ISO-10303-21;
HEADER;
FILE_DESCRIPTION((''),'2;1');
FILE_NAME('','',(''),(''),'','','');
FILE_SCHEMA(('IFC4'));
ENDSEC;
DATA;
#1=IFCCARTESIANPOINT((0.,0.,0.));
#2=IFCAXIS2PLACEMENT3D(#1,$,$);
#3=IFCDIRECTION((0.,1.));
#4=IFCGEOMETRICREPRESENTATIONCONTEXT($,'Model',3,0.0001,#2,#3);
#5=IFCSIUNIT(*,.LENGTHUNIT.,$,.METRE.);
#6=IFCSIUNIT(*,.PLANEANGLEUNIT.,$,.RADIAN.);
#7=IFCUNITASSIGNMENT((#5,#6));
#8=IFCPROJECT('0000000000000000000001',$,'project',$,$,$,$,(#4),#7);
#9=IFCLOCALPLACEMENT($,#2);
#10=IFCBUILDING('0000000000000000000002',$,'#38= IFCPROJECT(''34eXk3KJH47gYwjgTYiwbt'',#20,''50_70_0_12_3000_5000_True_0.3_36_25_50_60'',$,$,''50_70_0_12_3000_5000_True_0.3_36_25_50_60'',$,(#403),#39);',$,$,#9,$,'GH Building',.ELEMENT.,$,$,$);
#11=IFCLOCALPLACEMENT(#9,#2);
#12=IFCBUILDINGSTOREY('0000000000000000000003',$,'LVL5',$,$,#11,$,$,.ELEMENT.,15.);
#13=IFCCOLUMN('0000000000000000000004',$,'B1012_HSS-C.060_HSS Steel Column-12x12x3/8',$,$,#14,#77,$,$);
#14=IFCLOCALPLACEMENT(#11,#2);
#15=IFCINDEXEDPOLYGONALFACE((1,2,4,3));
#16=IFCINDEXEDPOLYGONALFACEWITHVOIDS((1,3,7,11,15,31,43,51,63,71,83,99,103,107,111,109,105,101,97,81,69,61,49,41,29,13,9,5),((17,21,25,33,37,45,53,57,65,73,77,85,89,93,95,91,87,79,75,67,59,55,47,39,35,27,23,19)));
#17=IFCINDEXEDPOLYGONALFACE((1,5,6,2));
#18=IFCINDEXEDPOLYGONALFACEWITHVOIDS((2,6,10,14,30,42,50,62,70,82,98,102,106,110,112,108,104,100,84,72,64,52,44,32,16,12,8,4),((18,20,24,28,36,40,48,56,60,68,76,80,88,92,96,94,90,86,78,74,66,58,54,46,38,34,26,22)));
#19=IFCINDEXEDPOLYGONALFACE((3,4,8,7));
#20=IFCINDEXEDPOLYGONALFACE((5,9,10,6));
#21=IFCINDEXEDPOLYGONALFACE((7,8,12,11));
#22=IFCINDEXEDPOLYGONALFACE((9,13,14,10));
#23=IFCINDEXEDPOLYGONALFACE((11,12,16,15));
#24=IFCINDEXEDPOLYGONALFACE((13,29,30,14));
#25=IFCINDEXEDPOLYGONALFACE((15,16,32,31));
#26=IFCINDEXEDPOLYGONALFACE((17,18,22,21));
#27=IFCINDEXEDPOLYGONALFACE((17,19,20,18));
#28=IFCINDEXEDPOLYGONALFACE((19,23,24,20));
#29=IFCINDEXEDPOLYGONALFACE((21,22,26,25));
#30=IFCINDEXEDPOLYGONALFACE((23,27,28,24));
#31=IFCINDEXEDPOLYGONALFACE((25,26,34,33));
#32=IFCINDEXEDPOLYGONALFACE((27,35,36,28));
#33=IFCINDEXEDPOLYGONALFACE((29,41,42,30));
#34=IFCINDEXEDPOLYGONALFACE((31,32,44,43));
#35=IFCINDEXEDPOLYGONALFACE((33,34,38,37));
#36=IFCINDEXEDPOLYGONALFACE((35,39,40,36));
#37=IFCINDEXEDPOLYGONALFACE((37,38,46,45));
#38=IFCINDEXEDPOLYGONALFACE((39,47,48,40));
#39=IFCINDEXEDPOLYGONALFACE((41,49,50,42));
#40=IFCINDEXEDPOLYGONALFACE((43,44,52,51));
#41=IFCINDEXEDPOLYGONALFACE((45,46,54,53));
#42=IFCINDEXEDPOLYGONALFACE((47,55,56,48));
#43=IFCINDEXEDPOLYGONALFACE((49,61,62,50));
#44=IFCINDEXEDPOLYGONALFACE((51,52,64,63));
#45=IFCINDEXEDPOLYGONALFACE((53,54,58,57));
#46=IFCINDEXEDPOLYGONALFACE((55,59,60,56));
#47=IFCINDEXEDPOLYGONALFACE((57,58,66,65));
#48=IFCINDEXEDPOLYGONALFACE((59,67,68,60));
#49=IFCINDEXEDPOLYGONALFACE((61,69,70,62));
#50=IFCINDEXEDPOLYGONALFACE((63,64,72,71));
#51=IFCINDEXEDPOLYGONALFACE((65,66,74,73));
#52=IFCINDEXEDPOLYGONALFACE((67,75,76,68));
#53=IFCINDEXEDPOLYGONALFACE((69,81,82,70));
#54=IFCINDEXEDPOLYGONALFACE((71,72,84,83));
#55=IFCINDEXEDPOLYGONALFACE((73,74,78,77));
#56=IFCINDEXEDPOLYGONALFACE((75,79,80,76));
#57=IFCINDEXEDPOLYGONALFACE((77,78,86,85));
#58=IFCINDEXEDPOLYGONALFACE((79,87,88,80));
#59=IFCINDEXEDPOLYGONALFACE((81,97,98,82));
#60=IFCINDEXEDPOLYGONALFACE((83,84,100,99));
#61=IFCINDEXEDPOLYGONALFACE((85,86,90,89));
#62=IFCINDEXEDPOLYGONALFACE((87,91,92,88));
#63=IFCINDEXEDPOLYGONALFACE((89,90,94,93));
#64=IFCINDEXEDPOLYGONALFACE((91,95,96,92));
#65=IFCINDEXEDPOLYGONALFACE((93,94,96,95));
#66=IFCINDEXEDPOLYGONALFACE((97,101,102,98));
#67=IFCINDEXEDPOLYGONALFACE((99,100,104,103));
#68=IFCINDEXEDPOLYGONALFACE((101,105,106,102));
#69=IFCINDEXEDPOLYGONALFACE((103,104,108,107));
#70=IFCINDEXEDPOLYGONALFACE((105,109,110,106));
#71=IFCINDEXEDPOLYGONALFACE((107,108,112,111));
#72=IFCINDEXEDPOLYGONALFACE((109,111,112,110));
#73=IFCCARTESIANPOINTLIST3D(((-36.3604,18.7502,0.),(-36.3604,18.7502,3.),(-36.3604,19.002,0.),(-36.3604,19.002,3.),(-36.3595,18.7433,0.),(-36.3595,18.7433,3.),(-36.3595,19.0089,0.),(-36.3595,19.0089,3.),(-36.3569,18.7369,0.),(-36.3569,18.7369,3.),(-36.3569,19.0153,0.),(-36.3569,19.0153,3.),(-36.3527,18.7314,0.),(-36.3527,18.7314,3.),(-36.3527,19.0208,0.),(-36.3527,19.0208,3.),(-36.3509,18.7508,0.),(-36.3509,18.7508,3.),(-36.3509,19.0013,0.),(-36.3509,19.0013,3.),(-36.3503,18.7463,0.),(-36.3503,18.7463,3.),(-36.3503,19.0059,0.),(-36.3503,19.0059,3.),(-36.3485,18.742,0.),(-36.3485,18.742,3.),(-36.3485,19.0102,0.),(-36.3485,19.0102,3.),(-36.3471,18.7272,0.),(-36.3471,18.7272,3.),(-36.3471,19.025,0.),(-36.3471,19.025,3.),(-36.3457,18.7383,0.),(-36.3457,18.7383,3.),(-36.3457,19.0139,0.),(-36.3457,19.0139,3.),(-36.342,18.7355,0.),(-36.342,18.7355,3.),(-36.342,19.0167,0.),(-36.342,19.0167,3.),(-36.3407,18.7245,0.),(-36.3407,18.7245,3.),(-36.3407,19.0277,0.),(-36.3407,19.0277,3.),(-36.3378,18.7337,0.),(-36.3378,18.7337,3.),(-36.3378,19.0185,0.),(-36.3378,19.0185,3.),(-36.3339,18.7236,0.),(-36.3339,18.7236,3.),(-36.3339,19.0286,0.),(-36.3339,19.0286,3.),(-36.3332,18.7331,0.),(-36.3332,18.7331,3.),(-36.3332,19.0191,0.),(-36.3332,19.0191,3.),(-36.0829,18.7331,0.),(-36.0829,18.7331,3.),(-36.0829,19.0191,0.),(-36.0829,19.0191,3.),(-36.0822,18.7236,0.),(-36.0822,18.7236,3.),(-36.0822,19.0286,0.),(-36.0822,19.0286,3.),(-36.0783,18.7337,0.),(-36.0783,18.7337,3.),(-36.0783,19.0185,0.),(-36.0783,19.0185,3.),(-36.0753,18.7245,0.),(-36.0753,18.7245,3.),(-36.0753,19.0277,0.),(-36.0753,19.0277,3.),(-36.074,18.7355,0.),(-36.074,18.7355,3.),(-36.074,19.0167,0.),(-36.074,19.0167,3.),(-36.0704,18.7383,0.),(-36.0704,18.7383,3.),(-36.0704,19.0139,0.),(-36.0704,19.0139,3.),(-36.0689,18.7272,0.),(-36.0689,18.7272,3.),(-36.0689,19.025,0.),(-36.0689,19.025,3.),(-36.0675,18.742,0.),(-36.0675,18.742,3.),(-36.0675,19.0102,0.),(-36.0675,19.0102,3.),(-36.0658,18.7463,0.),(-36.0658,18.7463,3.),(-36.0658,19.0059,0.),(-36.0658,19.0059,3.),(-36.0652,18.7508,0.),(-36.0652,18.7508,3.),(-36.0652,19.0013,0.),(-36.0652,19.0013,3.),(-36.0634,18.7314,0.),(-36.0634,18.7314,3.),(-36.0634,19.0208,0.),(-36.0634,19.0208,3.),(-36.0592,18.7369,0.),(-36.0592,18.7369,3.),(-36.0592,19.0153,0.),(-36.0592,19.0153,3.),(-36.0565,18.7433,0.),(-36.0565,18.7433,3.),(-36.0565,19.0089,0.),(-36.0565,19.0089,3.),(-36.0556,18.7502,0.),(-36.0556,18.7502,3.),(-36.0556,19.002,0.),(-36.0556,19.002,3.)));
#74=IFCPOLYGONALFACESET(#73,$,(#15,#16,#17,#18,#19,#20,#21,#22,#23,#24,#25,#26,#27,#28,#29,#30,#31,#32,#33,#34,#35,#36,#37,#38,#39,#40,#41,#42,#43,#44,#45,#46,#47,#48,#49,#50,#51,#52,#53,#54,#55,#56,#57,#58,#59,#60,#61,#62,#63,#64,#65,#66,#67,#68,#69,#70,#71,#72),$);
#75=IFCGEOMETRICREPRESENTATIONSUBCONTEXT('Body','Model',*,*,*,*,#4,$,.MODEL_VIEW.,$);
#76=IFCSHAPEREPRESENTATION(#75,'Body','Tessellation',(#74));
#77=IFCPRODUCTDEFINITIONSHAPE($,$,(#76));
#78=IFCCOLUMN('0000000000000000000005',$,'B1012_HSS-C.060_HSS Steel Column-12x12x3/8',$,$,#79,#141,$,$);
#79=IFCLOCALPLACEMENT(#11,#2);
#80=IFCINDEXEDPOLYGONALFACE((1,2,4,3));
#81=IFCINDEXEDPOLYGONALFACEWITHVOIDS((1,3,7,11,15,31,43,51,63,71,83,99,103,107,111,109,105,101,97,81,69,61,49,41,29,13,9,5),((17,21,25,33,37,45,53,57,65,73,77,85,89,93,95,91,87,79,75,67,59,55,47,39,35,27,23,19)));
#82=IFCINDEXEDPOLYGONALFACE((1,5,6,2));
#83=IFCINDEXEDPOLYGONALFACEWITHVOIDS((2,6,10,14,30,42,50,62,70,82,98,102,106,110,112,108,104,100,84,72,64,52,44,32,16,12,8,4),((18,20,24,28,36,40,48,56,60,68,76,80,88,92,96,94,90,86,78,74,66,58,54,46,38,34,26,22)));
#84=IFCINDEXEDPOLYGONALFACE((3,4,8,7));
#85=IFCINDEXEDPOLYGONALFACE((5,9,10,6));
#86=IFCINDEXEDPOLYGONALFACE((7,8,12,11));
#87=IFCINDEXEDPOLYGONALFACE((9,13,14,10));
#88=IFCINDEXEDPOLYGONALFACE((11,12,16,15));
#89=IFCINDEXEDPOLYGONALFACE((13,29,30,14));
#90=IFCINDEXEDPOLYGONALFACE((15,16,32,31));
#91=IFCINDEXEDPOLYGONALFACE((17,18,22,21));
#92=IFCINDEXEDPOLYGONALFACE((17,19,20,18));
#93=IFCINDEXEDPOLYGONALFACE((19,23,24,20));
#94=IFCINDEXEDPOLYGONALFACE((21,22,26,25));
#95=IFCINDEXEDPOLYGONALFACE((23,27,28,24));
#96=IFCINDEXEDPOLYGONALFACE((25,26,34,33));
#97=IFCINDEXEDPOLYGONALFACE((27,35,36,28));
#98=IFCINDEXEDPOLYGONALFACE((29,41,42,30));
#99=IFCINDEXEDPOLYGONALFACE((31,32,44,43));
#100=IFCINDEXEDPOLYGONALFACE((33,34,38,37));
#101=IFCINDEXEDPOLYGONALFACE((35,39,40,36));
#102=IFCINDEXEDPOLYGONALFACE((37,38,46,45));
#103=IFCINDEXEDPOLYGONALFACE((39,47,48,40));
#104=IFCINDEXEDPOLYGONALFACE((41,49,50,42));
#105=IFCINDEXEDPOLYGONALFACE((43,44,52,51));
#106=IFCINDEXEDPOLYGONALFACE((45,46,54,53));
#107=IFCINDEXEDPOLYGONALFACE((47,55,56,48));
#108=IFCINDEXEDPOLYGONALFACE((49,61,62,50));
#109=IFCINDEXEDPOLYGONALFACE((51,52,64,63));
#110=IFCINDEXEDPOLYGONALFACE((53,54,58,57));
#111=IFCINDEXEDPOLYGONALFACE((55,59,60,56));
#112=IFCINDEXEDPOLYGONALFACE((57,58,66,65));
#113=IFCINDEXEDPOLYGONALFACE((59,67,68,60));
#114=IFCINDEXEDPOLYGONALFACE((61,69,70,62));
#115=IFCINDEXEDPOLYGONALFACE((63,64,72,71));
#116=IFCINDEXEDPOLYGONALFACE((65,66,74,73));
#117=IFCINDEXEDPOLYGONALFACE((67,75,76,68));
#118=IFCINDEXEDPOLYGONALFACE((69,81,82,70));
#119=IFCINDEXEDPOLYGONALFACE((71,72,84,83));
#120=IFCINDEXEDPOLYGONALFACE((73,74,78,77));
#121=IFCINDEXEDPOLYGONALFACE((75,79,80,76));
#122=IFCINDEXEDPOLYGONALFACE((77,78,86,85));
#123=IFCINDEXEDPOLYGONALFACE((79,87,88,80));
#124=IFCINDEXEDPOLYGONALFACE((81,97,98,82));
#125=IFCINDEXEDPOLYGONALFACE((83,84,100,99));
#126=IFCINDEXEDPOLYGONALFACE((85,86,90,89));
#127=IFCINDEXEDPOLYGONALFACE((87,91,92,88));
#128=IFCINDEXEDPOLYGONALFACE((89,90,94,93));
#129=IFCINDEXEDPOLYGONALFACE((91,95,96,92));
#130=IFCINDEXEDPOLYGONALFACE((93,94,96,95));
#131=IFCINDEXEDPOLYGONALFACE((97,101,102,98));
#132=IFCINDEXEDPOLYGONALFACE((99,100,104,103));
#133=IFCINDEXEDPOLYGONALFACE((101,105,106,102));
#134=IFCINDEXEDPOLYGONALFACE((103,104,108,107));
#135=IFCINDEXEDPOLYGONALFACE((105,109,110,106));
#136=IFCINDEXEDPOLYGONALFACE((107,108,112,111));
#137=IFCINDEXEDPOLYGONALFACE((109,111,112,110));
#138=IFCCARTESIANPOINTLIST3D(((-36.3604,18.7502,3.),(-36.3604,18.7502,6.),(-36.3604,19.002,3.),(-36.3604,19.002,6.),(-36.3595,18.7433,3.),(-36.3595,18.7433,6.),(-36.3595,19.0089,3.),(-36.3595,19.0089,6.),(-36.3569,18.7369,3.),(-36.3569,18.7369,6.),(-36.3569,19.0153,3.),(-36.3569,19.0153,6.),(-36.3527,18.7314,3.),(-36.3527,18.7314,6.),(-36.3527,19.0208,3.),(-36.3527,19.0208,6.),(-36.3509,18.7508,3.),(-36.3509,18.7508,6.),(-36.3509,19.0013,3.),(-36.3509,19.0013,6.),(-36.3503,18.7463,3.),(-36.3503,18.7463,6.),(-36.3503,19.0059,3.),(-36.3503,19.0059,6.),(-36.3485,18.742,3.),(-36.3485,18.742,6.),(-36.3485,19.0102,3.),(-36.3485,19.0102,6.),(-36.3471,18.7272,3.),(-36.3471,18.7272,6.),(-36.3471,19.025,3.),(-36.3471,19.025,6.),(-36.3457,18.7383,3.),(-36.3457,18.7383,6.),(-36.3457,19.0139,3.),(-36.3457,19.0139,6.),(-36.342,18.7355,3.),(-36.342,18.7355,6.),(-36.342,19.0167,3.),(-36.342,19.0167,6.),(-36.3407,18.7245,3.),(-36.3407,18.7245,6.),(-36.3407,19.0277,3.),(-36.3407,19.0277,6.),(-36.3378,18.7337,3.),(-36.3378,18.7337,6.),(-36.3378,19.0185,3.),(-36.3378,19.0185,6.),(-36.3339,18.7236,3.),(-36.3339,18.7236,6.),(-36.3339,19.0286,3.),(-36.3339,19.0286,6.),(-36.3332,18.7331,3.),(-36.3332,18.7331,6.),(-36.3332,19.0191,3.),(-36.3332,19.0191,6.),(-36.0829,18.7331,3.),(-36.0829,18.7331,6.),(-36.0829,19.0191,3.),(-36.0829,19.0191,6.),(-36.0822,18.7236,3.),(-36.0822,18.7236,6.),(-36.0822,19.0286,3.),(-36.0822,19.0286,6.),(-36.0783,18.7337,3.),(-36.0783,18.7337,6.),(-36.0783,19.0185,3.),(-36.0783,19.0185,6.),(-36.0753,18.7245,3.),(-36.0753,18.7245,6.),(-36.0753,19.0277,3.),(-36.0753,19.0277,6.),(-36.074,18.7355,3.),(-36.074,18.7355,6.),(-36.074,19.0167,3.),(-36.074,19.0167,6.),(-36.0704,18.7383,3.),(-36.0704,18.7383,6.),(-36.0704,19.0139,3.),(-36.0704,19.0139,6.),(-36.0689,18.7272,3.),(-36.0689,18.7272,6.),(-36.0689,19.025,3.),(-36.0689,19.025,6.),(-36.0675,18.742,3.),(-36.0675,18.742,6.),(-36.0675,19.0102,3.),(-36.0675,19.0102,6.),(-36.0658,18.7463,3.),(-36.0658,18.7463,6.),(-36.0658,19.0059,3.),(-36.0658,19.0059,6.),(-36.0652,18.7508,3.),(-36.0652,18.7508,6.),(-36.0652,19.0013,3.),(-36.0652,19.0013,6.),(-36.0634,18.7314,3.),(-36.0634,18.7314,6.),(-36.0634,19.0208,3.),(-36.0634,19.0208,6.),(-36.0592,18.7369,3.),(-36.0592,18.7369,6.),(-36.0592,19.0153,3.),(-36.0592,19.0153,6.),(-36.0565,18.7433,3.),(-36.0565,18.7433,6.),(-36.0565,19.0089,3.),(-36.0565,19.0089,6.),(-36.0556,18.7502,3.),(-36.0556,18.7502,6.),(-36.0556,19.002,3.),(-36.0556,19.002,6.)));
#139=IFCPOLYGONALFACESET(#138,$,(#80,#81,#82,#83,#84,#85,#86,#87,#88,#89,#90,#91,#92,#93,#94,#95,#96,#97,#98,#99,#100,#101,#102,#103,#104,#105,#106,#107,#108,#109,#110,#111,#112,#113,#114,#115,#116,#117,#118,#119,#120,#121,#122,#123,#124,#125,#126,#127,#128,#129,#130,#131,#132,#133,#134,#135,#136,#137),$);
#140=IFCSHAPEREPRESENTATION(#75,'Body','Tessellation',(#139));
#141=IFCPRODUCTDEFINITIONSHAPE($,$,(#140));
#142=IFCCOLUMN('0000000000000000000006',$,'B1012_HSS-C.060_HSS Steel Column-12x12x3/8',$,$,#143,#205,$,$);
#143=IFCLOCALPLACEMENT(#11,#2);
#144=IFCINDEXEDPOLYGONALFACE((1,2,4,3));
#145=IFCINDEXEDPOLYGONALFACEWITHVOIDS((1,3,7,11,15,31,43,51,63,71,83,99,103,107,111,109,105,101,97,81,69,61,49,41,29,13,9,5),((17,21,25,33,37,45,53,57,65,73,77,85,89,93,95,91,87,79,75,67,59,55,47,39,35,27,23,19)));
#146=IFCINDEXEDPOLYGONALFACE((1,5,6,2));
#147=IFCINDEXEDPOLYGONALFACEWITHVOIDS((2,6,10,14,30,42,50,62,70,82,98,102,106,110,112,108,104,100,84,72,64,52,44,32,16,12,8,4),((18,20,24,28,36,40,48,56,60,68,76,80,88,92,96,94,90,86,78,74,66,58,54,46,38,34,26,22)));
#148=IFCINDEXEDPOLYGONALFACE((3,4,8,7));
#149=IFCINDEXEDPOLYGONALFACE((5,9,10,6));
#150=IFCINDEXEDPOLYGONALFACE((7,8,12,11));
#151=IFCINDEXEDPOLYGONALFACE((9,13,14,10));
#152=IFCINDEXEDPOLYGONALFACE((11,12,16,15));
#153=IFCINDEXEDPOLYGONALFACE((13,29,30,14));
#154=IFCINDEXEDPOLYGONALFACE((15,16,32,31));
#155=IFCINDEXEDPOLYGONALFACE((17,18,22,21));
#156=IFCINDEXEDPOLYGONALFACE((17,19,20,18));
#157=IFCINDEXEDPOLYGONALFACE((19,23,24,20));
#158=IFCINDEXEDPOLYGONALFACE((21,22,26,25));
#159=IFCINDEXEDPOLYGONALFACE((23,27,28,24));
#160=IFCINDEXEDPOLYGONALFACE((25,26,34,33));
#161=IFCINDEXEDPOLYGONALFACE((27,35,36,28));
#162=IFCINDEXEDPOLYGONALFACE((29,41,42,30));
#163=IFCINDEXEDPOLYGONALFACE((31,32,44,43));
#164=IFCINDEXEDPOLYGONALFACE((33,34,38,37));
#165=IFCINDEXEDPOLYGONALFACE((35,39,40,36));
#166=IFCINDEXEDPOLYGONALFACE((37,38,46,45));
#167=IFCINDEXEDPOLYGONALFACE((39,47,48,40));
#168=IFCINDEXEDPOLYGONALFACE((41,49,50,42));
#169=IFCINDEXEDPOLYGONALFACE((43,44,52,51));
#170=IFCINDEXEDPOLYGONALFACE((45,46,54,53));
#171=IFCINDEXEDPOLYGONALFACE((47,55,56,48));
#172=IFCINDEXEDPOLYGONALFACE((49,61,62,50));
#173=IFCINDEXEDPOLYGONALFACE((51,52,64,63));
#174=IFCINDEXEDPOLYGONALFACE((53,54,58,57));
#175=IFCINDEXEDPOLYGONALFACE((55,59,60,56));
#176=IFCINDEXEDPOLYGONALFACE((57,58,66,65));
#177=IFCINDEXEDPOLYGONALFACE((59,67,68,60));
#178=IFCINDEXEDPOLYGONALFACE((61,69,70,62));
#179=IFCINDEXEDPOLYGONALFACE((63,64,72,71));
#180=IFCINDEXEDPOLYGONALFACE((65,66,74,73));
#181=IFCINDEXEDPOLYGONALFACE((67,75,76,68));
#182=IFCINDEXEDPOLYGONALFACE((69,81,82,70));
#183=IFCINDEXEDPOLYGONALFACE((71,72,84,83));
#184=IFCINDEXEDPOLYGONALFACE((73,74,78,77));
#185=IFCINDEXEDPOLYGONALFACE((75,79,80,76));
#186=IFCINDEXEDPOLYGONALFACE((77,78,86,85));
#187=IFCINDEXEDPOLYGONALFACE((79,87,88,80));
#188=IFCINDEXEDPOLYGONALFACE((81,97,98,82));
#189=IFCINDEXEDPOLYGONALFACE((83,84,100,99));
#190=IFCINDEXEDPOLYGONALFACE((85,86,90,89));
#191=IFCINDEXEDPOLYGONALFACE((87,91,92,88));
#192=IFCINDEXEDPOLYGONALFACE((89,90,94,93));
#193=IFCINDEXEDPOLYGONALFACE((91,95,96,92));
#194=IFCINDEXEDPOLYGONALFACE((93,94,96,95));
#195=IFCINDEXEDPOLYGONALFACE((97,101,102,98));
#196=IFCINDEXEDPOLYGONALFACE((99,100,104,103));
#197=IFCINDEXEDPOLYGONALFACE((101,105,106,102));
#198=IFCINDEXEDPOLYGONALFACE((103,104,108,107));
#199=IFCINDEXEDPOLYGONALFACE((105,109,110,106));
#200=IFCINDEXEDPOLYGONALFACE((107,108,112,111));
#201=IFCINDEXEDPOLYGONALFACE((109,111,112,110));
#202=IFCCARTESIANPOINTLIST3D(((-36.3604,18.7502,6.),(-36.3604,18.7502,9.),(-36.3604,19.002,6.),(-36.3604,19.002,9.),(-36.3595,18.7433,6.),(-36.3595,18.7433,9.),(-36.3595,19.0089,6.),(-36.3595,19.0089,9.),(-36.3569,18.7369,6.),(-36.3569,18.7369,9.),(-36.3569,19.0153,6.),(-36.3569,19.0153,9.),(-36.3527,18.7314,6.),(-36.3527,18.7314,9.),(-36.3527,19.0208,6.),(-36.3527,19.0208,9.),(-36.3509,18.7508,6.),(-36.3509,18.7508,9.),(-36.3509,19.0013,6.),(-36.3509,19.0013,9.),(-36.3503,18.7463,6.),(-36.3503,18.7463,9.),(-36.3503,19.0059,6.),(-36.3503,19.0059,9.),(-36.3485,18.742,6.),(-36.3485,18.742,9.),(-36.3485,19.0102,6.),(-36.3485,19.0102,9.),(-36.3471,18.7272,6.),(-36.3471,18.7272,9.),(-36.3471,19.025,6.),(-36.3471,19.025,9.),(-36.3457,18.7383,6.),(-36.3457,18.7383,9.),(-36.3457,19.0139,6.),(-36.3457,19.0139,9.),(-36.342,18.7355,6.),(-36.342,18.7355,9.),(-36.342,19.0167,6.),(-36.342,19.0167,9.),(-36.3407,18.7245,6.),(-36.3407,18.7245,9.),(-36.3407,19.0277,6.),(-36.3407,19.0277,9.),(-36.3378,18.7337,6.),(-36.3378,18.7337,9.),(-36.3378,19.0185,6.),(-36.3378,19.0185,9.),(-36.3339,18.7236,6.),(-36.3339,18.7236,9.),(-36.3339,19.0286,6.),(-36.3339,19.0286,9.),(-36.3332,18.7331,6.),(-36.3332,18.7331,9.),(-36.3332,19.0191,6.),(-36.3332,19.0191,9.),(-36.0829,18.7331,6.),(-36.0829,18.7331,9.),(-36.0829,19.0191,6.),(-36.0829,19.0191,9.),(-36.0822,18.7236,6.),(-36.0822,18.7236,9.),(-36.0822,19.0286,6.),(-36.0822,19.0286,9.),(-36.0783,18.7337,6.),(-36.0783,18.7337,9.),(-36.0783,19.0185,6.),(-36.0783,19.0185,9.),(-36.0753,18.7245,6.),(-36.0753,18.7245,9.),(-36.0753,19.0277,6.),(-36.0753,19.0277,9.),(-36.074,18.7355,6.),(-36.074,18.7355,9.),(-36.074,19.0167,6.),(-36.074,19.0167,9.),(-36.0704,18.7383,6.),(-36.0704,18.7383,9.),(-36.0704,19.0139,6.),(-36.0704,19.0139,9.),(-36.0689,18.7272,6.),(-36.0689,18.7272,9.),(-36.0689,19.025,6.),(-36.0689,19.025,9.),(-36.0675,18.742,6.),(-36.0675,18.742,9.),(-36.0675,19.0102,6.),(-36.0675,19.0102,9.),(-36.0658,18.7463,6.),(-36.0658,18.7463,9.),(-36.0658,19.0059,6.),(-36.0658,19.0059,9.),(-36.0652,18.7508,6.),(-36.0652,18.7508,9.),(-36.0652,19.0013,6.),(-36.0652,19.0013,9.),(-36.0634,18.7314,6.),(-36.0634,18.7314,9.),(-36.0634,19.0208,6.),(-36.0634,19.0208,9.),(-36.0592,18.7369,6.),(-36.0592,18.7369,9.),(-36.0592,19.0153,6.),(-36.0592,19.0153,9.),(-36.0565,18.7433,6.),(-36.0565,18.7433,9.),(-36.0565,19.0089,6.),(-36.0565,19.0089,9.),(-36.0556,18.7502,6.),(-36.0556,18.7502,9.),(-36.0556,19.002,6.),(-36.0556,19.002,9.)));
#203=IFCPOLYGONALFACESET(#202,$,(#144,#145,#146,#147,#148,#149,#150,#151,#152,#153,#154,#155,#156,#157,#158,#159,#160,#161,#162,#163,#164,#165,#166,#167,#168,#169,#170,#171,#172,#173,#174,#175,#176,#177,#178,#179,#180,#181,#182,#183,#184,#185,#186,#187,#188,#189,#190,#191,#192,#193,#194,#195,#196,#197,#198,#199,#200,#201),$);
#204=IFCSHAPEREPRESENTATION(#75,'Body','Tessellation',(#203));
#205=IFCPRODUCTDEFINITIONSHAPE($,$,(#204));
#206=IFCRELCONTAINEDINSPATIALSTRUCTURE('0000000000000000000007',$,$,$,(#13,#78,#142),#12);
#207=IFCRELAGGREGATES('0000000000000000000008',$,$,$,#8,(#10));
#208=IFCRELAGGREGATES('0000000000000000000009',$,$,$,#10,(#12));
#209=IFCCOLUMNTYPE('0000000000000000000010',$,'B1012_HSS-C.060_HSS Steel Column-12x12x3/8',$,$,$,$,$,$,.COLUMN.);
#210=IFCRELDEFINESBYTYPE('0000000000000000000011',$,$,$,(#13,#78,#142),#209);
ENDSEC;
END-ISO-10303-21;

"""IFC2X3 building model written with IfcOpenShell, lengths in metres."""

from ifc_helpers import new_model, si_unit, direction, frame, origin, origin_2d, place, context, subcontext, project, spatial, hollow_rectangle, extrude, type_object, element, save


model = new_model("IFC2X3")

# Units and contexts
model_context = context("Model", 3, precision=0.0001, world=origin(), true_north=direction((0.0, 1.0)))
body_context = subcontext(model_context, "Body", "Model", "MODEL_VIEW")
ifc_project = project(units=[si_unit("LENGTHUNIT", "METRE"), si_unit("PLANEANGLEUNIT", "RADIAN")], contexts=[model_context])

# Building, storey
building_placement = place(None, origin())
building = spatial("IfcBuilding", under=ifc_project, at=building_placement, Name="#38= IFCPROJECT('34eXk3KJH47gYwjgTYiwbt',#20,'50_70_0_12_3000_5000_True_0.3_36_25_50_60',$,$,'50_70_0_12_3000_5000_True_0.3_36_25_50_60',$,(#403),#39);", LongName="GH Building", CompositionType="ELEMENT")
storey_placement = place(building_placement, origin())
storey = spatial("IfcBuildingStorey", under=building, at=storey_placement, Name="LVL5", CompositionType="ELEMENT", Elevation=15.0)

# Columns
column_type = type_object("IfcColumnType", Name="B1012_HSS-C.060_HSS Steel Column-12x12x3/8", PredefinedType="COLUMN")
for number, where, z_axis, x_axis, name in (
    (1, (-36.208, 18.8761, 3.0), (0.0, 0.0, -1.0), (-1.0, 0.0, 0.0), "B1012_HSS-C.060_HSS Steel Column-12x12x3/8"),
    (2, (-36.208, 18.8761, 6.0), (0.0, 0.0, -1.0), (-1.0, 0.0, 0.0), "B1012_HSS-C.060_HSS Steel Column-12x12x3/8"),
    (3, (-36.208, 18.8761, 9.0), (0.0, 0.0, -1.0), (-1.0, 0.0, 0.0), "B1012_HSS-C.060_HSS Steel Column-12x12x3/8"),
):
    element("IfcColumn", number, at=place(storey_placement, frame(where, z_axis=z_axis, x_axis=x_axis)), inside=storey, type_object=column_type, Name=name, context=body_context, shape_type="SweptSolid", body=[
        extrude(hollow_rectangle(XDim=0.3048, YDim=0.305, WallThickness=0.0095, InnerFilletRadius=0.0177, OuterFilletRadius=0.0266, at=origin_2d()), origin(), (0.0, 0.0, 1.0), 3.0),
    ])

save(model, "model.ifc")
